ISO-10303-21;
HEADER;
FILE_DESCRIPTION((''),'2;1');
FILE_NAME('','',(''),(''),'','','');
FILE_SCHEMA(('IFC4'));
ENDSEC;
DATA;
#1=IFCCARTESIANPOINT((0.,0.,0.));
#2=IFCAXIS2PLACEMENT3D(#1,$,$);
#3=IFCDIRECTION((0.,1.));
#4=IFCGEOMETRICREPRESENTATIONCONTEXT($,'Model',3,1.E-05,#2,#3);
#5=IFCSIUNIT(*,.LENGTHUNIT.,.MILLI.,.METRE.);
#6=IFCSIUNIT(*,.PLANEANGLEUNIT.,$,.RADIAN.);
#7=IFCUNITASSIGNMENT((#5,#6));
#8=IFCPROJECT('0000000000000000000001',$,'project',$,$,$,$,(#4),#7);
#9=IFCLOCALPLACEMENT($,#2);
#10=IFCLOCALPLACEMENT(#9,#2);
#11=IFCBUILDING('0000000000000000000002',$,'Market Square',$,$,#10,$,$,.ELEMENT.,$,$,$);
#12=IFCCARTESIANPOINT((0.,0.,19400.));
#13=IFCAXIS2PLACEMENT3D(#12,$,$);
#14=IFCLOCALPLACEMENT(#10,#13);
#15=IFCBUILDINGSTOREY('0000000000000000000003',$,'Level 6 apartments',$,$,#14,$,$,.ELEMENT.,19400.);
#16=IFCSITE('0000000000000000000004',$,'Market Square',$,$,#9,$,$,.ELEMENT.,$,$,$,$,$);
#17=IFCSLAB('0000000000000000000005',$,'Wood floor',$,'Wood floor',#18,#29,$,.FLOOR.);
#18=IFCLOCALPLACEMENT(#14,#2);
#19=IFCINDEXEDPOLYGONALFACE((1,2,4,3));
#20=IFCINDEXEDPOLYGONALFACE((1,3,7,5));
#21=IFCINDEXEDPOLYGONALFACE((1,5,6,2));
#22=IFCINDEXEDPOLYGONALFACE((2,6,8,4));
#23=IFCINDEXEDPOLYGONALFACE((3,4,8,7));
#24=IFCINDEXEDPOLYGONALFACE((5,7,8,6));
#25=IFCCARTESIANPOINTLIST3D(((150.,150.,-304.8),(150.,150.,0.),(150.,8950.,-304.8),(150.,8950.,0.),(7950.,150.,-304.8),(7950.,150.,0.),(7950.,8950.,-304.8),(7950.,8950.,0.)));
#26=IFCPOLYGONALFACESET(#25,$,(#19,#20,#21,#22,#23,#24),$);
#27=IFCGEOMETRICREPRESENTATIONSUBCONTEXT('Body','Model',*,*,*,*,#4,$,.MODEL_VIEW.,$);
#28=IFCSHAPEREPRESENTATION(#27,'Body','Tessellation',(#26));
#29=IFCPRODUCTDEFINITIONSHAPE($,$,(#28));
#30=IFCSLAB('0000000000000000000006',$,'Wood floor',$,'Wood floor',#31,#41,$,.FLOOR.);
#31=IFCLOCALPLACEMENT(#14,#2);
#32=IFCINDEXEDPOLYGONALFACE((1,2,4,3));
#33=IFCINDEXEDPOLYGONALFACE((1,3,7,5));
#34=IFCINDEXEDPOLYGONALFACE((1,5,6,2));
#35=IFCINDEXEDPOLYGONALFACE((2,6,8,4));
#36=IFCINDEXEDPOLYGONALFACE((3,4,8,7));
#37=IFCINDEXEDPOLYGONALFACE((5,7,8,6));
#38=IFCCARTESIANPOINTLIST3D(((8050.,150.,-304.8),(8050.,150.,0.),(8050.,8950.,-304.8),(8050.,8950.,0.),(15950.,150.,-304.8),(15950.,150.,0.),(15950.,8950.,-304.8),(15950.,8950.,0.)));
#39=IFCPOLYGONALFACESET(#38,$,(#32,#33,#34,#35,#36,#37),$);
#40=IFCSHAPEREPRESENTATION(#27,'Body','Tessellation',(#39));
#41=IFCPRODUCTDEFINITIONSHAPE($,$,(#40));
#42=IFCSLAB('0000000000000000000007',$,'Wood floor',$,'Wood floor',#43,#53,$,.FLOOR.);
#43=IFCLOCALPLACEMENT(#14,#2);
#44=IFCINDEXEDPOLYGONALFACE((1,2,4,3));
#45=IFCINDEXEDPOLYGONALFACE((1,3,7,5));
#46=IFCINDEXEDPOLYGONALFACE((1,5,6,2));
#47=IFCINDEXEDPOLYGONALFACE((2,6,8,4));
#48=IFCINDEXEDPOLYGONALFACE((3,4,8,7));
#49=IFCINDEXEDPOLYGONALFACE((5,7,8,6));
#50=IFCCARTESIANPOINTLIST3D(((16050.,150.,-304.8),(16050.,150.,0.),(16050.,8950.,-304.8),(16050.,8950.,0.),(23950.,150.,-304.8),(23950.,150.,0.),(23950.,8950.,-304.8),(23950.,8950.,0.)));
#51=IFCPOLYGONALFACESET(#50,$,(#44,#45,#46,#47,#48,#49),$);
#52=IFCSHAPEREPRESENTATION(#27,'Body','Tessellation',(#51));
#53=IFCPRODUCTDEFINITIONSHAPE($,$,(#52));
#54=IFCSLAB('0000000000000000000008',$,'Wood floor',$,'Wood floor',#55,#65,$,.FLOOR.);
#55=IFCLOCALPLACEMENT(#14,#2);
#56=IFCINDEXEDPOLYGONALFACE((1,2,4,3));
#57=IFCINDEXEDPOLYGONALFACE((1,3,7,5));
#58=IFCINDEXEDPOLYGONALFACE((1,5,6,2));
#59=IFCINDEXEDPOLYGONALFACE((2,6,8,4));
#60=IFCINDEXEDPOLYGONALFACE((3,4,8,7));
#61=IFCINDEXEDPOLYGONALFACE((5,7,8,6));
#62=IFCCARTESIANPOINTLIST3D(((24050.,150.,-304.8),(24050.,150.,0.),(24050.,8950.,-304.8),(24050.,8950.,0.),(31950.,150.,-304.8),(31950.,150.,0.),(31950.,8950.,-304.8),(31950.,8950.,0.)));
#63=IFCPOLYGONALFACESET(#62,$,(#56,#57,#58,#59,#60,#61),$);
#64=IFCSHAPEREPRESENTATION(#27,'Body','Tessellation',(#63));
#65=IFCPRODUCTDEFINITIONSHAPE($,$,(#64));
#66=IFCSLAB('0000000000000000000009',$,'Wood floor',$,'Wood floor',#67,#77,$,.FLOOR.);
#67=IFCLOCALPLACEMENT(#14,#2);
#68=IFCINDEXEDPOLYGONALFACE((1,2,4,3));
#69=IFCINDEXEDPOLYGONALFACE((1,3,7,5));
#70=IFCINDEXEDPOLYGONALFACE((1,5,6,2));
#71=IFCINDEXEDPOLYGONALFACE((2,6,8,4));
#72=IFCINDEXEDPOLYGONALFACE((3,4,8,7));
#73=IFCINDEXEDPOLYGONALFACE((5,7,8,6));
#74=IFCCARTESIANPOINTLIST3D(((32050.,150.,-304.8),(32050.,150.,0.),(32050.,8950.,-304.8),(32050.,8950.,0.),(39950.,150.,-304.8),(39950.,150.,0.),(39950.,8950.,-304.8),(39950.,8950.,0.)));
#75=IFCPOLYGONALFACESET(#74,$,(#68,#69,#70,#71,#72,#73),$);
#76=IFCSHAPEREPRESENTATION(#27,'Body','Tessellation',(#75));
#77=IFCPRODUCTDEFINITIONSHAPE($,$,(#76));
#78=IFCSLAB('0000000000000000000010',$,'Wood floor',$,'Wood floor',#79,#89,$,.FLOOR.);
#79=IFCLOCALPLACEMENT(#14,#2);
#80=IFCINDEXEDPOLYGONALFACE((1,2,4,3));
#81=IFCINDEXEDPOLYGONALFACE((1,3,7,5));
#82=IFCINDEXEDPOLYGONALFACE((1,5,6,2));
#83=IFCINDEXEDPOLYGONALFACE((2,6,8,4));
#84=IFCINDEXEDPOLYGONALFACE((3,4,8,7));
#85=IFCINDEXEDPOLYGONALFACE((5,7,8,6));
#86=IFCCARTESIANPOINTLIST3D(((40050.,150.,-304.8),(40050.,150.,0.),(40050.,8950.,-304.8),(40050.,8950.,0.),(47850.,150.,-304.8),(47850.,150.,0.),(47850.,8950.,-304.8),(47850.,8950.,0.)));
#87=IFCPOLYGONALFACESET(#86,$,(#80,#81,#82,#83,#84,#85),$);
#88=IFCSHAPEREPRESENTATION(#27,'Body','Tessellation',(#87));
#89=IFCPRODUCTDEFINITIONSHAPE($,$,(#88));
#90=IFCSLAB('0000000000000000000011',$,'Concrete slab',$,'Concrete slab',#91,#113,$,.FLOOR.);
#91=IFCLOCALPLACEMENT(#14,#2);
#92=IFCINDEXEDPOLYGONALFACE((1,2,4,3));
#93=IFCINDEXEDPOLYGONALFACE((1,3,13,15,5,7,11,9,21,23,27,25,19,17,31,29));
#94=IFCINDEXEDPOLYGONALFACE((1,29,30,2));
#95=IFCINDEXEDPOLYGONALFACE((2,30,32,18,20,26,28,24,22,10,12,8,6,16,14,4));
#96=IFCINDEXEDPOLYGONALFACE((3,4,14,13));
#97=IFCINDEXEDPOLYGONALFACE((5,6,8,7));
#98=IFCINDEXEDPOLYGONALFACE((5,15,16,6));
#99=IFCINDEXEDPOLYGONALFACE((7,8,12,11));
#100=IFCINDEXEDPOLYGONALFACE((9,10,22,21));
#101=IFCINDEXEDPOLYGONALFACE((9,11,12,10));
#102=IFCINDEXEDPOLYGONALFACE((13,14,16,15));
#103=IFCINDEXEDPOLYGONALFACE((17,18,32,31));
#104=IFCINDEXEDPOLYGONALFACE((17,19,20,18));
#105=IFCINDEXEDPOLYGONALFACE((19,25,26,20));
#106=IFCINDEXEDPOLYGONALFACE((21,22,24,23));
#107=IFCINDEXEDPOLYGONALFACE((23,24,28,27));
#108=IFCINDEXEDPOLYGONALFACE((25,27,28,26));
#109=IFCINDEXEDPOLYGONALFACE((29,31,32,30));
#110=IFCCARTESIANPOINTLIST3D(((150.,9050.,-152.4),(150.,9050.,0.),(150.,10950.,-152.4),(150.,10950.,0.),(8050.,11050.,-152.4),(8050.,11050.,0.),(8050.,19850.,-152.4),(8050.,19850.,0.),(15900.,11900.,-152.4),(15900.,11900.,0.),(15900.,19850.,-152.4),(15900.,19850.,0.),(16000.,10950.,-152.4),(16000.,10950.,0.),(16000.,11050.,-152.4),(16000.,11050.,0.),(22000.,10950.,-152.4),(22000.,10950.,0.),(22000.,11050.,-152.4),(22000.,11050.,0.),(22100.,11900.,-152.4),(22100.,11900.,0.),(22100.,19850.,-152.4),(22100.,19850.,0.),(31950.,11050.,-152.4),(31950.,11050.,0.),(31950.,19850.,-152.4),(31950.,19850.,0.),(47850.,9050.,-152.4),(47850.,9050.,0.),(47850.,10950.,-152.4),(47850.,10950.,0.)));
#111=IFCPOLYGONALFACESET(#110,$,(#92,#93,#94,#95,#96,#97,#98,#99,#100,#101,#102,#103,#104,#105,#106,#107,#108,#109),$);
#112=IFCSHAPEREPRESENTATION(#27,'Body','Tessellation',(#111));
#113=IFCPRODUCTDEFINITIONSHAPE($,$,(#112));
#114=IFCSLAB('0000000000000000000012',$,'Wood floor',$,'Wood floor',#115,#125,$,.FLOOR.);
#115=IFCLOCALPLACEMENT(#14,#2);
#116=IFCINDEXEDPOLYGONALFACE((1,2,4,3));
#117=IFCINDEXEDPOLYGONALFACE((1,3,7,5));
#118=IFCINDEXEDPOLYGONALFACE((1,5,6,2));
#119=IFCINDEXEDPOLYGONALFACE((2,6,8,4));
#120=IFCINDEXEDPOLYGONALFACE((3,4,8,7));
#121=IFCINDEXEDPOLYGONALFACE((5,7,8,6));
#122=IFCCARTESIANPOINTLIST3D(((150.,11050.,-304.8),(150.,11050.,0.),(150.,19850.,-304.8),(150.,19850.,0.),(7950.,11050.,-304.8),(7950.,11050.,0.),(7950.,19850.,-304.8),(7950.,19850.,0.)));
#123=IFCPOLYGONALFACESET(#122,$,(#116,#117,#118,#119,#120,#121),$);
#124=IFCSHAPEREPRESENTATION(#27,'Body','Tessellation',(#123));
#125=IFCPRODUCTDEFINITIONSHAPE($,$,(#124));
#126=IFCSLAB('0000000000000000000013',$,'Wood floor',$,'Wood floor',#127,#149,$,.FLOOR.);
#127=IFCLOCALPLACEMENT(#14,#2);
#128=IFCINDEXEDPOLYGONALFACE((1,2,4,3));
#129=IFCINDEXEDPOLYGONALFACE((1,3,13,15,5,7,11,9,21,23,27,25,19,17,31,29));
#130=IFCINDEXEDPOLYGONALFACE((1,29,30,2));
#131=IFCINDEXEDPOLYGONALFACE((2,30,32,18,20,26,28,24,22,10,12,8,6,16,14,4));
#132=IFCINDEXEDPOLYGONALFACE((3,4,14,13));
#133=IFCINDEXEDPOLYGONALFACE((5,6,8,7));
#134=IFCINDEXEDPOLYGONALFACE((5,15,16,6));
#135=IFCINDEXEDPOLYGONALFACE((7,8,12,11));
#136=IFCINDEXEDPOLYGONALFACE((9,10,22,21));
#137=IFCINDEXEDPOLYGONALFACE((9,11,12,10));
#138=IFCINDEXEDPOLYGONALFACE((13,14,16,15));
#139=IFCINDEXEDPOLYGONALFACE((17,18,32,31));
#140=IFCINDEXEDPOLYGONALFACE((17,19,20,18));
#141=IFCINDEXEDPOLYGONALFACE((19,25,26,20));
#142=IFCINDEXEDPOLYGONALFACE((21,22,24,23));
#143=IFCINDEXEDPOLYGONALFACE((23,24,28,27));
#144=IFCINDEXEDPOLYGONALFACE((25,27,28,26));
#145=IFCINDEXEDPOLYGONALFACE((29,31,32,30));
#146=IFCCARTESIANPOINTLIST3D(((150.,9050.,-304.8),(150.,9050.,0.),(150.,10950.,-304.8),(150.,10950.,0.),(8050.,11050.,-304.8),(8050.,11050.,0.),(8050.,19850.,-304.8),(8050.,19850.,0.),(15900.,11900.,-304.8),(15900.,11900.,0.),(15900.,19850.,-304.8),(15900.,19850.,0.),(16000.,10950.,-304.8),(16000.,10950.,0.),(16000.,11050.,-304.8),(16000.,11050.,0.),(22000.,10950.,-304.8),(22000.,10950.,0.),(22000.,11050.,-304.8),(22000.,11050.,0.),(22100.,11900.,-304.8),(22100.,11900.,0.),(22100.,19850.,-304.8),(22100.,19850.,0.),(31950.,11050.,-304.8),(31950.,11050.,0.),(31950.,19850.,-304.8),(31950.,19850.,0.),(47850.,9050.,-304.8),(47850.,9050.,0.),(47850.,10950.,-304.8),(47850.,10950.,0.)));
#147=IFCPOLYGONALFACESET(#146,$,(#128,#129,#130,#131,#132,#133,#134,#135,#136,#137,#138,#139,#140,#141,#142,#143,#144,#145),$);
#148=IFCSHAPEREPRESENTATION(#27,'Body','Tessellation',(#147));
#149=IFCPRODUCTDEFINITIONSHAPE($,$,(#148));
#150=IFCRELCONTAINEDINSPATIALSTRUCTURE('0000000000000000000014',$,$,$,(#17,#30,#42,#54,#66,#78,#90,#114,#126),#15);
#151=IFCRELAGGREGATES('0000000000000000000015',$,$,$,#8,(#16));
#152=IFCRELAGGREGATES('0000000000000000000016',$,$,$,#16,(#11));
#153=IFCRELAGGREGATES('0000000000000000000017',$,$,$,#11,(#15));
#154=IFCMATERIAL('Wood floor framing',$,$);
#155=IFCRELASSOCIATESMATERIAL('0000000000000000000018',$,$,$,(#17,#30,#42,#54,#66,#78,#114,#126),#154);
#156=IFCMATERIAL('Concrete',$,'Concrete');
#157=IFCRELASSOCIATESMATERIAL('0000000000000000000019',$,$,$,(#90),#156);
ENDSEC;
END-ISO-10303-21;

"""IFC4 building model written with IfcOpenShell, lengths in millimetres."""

from ifc_helpers import new_model, si_unit, direction, frame, origin, origin_with_axes, place, context, subcontext, project, spatial, polyline, outline, extrude, material, element, save


model = new_model("IFC4")

# Units and contexts
model_context = context("Model", 3, precision=1e-05, world=origin(), true_north=direction((0.0, 1.0)))
body_context = subcontext(model_context, "Body", "Model", "MODEL_VIEW")
ifc_project = project(units=[si_unit("LENGTHUNIT", "METRE", prefix="MILLI"), si_unit("PLANEANGLEUNIT", "RADIAN")], contexts=[model_context])

# Site, building, storey
site_placement = place(None, origin())
site = spatial("IfcSite", under=ifc_project, at=site_placement, Name="Market Square", CompositionType="ELEMENT")
building_placement = place(site_placement, origin())
building = spatial("IfcBuilding", under=site, at=building_placement, Name="Market Square", CompositionType="ELEMENT")
storey_placement = place(building_placement, frame((0.0, 0.0, 19400.0)))
storey = spatial("IfcBuildingStorey", under=building, at=storey_placement, Name="Level 6 apartments", CompositionType="ELEMENT", Elevation=19400.0)

# Slabs
ifc_material_1 = material(Name="Wood floor framing")
slab_1_placement = place(storey_placement, origin_with_axes())
element("IfcSlab", 1, at=slab_1_placement, inside=storey, material=ifc_material_1, Name="Wood floor", ObjectType="Wood floor", PredefinedType="FLOOR", context=body_context, shape_type="SweptSolid", body=[
    extrude(outline(polyline([(150.0, 150.0), (7950.0, 150.0), (7950.0, 8950.0), (150.0, 8950.0), (150.0, 150.0)])), frame((0.0, 0.0, -304.8)), (0.0, 0.0, 1.0), 304.8),
])
slab_2_placement = place(storey_placement, origin_with_axes())
element("IfcSlab", 2, at=slab_2_placement, inside=storey, material=ifc_material_1, Name="Wood floor", ObjectType="Wood floor", PredefinedType="FLOOR", context=body_context, shape_type="SweptSolid", body=[
    extrude(outline(polyline([(8050.0, 150.0), (15950.0, 150.0), (15950.0, 8950.0), (8050.0, 8950.0), (8050.0, 150.0)])), frame((0.0, 0.0, -304.8)), (0.0, 0.0, 1.0), 304.8),
])
slab_3_placement = place(storey_placement, origin_with_axes())
element("IfcSlab", 3, at=slab_3_placement, inside=storey, material=ifc_material_1, Name="Wood floor", ObjectType="Wood floor", PredefinedType="FLOOR", context=body_context, shape_type="SweptSolid", body=[
    extrude(outline(polyline([(16050.0, 150.0), (23950.0, 150.0), (23950.0, 8950.0), (16050.0, 8950.0), (16050.0, 150.0)])), frame((0.0, 0.0, -304.8)), (0.0, 0.0, 1.0), 304.8),
])
slab_4_placement = place(storey_placement, origin_with_axes())
element("IfcSlab", 4, at=slab_4_placement, inside=storey, material=ifc_material_1, Name="Wood floor", ObjectType="Wood floor", PredefinedType="FLOOR", context=body_context, shape_type="SweptSolid", body=[
    extrude(outline(polyline([(24050.0, 150.0), (31950.0, 150.0), (31950.0, 8950.0), (24050.0, 8950.0), (24050.0, 150.0)])), frame((0.0, 0.0, -304.8)), (0.0, 0.0, 1.0), 304.8),
])
slab_5_placement = place(storey_placement, origin_with_axes())
element("IfcSlab", 5, at=slab_5_placement, inside=storey, material=ifc_material_1, Name="Wood floor", ObjectType="Wood floor", PredefinedType="FLOOR", context=body_context, shape_type="SweptSolid", body=[
    extrude(outline(polyline([(32050.0, 150.0), (39950.0, 150.0), (39950.0, 8950.0), (32050.0, 8950.0), (32050.0, 150.0)])), frame((0.0, 0.0, -304.8)), (0.0, 0.0, 1.0), 304.8),
])
slab_6_placement = place(storey_placement, origin_with_axes())
element("IfcSlab", 6, at=slab_6_placement, inside=storey, material=ifc_material_1, Name="Wood floor", ObjectType="Wood floor", PredefinedType="FLOOR", context=body_context, shape_type="SweptSolid", body=[
    extrude(outline(polyline([(40050.0, 150.0), (47850.0, 150.0), (47850.0, 8950.0), (40050.0, 8950.0), (40050.0, 150.0)])), frame((0.0, 0.0, -304.8)), (0.0, 0.0, 1.0), 304.8),
])
ifc_material_2 = material(Name="Concrete", Category="Concrete")
slab_7_placement = place(storey_placement, origin_with_axes())
element("IfcSlab", 7, at=slab_7_placement, inside=storey, material=ifc_material_2, Name="Concrete slab", ObjectType="Concrete slab", PredefinedType="FLOOR", context=body_context, shape_type="SweptSolid", body=[
    extrude(outline(polyline([(47850.0, 9050.0), (47850.0, 10950.0), (22000.0, 10950.0), (22000.0, 11050.0), (31950.0, 11050.0), (31950.0, 19850.0), (22100.0, 19850.0), (22100.0, 11900.0), (15900.0, 11900.0), (15900.0, 19850.0), (8050.0, 19850.0), (8050.0, 11050.0), (16000.0, 11050.0), (16000.0, 10950.0), (150.0, 10950.0), (150.0, 9050.0), (47850.0, 9050.0)])), frame((0.0, 0.0, -152.4)), (0.0, 0.0, 1.0), 152.4),
])
slab_8_placement = place(storey_placement, origin_with_axes())
element("IfcSlab", 8, at=slab_8_placement, inside=storey, material=ifc_material_1, Name="Wood floor", ObjectType="Wood floor", PredefinedType="FLOOR", context=body_context, shape_type="SweptSolid", body=[
    extrude(outline(polyline([(7950.0, 19850.0), (150.0, 19850.0), (150.0, 11050.0), (7950.0, 11050.0), (7950.0, 19850.0)])), frame((0.0, 0.0, -304.8)), (0.0, 0.0, 1.0), 304.8),
])
for number, where, z_axis, x_axis, name in (
    (9, (0.0, 0.0, 0.0), (0.0, 0.0, 1.0), (1.0, 0.0, 0.0), "Wood floor"),
):
    element("IfcSlab", number, at=place(storey_placement, frame(where, z_axis=z_axis, x_axis=x_axis)), inside=storey, material=ifc_material_1, Name=name, ObjectType="Wood floor", PredefinedType="FLOOR", context=body_context, shape_type="SweptSolid", body=[
        extrude(outline(polyline([(47850.0, 9050.0), (47850.0, 10950.0), (22000.0, 10950.0), (22000.0, 11050.0), (31950.0, 11050.0), (31950.0, 19850.0), (22100.0, 19850.0), (22100.0, 11900.0), (15900.0, 11900.0), (15900.0, 19850.0), (8050.0, 19850.0), (8050.0, 11050.0), (16000.0, 11050.0), (16000.0, 10950.0), (150.0, 10950.0), (150.0, 9050.0), (47850.0, 9050.0)])), frame((0.0, 0.0, -304.8)), (0.0, 0.0, 1.0), 304.8),
    ])

save(model, "model.ifc")
